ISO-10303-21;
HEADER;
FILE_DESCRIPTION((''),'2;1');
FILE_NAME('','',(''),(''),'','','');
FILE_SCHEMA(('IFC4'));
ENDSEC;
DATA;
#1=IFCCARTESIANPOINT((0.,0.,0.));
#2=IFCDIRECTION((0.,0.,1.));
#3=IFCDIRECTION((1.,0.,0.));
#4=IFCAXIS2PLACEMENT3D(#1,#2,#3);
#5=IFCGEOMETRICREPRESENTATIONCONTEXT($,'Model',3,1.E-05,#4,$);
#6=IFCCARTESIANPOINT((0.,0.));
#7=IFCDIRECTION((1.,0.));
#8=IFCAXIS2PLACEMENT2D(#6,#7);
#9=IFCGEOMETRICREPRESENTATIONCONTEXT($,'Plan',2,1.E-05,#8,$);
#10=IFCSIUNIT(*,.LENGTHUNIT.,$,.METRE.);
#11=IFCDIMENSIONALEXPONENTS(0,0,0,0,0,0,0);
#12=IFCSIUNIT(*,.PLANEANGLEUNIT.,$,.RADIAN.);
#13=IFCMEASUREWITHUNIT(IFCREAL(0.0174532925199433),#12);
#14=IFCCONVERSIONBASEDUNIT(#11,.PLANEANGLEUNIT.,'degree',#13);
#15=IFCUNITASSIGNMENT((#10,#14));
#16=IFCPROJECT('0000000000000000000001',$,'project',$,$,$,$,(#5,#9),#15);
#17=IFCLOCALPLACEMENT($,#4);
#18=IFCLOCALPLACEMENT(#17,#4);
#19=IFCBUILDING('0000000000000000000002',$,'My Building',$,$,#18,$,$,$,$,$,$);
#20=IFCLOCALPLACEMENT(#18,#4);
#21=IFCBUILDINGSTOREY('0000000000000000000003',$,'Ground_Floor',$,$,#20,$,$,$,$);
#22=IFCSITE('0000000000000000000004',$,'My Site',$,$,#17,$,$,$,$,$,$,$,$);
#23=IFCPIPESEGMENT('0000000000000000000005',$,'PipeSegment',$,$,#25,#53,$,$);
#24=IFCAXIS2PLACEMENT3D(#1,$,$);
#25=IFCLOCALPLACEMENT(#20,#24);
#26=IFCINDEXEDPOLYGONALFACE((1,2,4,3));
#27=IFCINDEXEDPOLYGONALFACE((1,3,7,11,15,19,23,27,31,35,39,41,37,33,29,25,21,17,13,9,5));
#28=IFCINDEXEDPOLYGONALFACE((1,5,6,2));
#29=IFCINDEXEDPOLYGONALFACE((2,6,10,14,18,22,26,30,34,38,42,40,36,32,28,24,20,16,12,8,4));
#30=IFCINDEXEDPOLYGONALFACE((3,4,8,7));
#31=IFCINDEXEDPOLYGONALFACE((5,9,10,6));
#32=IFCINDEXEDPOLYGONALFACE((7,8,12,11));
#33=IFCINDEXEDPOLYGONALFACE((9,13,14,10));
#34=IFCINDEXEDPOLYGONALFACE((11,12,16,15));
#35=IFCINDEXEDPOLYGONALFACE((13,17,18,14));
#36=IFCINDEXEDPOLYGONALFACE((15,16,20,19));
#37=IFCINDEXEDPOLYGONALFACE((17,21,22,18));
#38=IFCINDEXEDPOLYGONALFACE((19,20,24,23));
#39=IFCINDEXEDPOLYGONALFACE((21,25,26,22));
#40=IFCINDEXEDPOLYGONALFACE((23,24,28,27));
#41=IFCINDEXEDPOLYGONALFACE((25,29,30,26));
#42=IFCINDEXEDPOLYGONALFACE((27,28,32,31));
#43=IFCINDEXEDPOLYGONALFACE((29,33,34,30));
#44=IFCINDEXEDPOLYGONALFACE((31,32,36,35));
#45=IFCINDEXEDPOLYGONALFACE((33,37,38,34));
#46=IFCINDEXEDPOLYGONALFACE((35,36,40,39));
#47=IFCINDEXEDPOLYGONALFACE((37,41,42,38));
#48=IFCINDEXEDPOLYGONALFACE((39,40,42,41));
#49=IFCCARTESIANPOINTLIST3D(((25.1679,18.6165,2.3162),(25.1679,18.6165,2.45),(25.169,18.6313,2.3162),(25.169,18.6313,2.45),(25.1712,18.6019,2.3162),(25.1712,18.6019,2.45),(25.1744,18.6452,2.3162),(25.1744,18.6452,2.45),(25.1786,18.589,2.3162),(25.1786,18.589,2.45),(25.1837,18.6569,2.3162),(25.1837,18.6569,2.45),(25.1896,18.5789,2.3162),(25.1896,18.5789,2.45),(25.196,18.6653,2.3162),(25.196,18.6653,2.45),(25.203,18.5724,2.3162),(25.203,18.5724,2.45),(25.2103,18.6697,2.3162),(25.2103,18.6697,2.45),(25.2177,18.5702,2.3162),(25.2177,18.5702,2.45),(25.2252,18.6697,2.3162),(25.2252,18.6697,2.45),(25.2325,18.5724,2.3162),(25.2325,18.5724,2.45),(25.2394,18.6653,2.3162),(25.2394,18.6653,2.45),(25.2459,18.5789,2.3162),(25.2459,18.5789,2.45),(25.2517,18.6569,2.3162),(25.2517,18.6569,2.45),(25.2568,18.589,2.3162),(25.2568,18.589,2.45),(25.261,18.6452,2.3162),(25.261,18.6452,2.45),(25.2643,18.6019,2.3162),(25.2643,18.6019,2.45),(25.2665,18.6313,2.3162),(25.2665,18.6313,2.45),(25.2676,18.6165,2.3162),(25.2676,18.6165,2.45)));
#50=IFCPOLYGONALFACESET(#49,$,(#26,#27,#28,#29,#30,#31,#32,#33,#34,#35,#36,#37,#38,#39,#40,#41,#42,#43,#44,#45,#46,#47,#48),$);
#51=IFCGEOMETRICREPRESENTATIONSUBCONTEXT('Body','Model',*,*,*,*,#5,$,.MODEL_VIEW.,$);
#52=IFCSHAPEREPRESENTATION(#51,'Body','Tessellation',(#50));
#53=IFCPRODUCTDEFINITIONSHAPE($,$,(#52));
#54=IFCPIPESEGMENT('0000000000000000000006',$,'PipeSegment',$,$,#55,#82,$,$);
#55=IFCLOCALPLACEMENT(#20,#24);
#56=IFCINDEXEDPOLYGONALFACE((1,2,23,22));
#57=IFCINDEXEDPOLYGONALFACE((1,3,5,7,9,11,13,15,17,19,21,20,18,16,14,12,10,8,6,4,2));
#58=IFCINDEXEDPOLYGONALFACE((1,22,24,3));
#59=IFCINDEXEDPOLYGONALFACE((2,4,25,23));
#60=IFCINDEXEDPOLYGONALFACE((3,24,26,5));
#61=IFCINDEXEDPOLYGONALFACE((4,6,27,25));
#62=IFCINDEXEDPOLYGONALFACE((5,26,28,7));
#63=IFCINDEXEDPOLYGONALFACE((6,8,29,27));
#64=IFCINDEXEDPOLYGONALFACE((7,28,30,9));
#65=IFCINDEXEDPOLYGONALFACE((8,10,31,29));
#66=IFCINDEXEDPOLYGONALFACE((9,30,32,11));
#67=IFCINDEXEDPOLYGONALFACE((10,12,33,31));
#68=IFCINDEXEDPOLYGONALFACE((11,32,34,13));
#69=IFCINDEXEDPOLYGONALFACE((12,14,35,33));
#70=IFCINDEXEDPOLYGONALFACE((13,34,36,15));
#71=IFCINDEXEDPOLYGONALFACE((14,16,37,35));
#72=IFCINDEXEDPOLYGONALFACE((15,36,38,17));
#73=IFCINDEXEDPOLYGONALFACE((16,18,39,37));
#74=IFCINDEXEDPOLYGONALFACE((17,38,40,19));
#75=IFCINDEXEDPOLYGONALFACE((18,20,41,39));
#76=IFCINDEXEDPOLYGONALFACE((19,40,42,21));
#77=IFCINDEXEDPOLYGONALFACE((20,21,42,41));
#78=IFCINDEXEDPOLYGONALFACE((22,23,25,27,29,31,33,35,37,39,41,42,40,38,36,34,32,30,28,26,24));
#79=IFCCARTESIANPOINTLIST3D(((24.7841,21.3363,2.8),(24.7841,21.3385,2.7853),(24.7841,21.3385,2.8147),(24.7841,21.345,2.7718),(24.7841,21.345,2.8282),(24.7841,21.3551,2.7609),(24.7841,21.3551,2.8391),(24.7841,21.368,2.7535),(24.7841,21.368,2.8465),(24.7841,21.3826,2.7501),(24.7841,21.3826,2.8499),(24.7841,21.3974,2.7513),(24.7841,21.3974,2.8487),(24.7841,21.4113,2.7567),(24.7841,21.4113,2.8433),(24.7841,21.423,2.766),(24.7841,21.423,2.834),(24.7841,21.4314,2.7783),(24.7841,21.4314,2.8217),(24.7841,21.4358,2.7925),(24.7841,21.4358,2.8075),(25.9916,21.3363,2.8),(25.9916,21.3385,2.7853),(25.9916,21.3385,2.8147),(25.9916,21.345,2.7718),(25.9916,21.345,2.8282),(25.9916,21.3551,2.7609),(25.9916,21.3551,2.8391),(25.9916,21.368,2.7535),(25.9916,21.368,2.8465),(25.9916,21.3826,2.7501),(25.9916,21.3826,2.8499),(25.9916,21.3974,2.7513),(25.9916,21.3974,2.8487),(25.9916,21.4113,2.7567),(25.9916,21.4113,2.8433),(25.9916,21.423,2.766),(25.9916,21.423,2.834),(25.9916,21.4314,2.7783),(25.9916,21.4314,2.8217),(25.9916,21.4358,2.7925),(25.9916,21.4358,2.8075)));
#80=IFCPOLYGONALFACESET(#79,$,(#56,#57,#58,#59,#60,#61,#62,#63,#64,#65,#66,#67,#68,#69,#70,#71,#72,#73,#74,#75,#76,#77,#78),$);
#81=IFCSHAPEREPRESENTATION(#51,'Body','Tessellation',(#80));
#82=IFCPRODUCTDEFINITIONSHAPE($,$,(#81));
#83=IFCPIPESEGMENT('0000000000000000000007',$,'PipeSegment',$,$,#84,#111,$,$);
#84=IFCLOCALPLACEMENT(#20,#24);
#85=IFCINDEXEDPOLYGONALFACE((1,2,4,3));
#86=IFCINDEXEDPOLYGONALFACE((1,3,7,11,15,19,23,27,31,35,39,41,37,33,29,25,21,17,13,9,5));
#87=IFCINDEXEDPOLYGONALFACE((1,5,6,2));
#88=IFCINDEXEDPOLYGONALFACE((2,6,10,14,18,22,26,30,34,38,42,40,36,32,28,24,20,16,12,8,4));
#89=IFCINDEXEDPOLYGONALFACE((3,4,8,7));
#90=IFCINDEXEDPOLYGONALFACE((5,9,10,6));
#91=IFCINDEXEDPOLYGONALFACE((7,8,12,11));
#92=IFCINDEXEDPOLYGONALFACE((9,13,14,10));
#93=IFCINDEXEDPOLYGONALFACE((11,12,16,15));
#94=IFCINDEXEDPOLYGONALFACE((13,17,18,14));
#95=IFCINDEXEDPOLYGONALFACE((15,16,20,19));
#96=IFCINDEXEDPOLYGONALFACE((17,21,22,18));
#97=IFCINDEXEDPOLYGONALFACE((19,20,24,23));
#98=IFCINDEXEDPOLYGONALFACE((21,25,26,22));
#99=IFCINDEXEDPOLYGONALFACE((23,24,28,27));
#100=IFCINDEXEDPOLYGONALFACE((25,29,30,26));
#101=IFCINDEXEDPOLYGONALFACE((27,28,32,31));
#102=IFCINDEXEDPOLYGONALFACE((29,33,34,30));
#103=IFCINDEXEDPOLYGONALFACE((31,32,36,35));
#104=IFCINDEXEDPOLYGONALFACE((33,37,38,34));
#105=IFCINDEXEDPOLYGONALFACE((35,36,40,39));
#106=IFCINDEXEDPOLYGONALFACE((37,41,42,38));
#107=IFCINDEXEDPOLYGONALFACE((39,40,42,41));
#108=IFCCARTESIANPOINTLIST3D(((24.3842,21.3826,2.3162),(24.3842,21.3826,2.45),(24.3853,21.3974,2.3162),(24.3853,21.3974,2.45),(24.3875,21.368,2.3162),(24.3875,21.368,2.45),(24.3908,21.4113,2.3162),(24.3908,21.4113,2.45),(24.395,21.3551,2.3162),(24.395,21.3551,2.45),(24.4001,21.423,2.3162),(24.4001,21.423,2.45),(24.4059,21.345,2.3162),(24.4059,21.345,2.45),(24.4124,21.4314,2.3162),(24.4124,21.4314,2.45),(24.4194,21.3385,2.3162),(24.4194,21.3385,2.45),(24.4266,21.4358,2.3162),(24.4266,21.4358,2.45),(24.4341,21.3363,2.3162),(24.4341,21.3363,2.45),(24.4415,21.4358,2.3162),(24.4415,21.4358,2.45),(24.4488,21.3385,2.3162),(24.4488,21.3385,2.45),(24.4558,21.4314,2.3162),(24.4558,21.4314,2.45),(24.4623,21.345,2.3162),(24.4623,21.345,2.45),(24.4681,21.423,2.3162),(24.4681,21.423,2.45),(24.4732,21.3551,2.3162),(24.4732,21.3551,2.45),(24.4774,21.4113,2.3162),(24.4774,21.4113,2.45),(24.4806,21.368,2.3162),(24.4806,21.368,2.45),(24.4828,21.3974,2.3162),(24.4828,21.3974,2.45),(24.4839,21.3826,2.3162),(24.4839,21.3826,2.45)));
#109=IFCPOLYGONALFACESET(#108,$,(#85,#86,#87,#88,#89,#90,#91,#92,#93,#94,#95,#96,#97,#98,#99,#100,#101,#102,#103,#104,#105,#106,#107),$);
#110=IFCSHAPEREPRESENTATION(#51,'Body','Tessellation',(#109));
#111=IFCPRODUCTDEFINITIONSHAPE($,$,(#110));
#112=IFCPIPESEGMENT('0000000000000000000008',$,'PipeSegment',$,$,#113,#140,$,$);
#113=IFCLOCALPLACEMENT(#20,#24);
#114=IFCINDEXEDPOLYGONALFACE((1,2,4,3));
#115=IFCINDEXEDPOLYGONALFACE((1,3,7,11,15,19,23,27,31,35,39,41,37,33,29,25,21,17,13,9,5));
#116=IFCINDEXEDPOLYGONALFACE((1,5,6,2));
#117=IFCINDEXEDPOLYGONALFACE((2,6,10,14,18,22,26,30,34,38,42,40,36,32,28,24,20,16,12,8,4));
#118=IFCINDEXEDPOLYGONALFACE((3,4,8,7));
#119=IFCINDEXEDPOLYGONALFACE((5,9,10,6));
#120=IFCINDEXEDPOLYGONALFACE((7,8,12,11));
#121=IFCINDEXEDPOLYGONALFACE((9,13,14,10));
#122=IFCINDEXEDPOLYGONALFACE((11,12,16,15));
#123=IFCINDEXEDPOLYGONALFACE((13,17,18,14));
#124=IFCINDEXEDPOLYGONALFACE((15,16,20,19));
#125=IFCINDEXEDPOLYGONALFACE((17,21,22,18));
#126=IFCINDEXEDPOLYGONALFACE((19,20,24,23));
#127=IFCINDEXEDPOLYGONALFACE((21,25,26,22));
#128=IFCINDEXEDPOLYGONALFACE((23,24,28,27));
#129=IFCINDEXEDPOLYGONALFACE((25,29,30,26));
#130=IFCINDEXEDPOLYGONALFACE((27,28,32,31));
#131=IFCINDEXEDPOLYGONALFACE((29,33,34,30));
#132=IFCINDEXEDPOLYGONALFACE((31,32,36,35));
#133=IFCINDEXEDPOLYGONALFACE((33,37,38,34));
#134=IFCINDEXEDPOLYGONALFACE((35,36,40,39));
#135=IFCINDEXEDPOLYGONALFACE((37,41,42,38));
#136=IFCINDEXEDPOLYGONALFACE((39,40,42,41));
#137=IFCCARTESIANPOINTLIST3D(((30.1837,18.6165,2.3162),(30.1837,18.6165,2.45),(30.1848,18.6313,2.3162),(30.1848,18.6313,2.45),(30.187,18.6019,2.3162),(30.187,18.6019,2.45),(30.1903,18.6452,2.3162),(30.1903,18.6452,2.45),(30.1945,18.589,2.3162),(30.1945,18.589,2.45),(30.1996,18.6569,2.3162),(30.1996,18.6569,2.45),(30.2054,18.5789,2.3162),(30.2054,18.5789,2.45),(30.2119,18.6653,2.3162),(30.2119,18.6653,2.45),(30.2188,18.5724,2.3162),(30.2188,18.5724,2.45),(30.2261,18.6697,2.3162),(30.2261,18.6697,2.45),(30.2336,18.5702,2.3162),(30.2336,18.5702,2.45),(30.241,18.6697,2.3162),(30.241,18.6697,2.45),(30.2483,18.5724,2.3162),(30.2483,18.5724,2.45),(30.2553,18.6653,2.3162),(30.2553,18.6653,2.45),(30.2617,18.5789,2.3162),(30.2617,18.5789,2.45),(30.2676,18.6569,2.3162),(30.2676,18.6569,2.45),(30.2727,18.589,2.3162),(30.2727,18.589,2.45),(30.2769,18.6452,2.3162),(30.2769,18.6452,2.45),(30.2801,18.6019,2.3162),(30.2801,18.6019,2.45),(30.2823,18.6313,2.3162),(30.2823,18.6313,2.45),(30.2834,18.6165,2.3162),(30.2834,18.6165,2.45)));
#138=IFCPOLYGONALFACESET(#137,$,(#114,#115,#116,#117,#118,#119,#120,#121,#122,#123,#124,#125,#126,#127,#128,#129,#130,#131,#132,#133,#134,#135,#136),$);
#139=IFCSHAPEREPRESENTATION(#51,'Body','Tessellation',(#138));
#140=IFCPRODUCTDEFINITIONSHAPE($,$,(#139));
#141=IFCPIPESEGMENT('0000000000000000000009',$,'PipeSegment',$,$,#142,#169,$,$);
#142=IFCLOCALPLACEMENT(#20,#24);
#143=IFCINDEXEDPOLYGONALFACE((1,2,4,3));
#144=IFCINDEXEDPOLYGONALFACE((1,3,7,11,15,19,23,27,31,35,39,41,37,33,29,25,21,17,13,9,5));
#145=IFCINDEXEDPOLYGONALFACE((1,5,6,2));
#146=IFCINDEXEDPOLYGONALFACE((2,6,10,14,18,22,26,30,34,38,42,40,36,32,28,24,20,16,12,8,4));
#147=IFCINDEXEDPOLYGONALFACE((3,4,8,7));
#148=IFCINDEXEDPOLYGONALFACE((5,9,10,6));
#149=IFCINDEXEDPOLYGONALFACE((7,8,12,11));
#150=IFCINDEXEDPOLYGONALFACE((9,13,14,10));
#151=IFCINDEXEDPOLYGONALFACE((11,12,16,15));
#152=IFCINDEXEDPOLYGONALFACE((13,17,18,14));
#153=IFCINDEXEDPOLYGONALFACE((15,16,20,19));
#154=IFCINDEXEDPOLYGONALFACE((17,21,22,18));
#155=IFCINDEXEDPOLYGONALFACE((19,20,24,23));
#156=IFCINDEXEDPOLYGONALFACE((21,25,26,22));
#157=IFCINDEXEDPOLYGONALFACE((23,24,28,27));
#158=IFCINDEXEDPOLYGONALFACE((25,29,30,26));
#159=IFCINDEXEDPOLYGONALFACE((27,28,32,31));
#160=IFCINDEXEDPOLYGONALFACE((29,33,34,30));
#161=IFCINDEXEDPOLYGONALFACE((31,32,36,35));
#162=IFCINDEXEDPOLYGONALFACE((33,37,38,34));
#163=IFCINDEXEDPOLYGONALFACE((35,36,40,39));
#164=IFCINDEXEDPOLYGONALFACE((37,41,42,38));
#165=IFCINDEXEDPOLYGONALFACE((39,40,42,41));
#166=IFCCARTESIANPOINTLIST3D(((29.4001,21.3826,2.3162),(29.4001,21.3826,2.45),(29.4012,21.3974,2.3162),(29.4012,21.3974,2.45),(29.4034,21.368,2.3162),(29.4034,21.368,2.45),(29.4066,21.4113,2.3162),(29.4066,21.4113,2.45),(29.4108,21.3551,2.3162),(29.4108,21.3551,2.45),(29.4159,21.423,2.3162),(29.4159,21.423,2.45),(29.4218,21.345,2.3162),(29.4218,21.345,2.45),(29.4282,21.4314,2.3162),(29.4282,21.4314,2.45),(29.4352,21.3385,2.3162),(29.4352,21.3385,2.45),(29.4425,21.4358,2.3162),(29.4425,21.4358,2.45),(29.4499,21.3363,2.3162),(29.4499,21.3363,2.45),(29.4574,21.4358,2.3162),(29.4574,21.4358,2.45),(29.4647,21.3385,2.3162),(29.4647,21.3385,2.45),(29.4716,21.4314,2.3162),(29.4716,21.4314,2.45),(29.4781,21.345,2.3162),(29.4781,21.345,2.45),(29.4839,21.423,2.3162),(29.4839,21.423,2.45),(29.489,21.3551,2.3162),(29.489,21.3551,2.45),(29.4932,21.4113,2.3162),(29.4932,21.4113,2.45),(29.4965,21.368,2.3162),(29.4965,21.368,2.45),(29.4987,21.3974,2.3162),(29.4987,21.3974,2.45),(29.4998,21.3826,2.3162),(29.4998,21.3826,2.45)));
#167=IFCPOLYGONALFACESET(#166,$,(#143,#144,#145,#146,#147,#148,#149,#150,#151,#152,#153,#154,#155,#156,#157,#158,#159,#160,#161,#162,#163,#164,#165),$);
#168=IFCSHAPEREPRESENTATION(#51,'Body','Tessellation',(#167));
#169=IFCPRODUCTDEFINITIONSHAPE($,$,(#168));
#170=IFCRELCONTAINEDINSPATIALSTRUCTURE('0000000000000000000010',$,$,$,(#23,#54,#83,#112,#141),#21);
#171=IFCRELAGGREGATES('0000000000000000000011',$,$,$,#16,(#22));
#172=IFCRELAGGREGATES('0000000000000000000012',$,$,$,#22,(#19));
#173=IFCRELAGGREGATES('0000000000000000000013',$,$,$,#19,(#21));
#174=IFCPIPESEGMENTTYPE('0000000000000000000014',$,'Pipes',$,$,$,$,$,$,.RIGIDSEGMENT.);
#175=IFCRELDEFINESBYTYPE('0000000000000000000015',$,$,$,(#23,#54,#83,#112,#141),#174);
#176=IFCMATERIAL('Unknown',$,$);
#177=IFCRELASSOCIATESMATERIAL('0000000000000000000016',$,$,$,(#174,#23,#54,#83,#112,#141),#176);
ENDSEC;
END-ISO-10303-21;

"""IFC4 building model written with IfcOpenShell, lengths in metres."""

from ifc_helpers import new_model, entity, si_unit, converted_unit, frame, origin_with_axes, origin_2d_with_axis, place, context, subcontext, project, spatial, circle, extrude, material, material_profile, profile_set, profile_usage, type_object, element, save


model = new_model("IFC4")

# Units and contexts
model_context = context("Model", 3, precision=1e-05, world=origin_with_axes())
plan_context = context("Plan", 2, precision=1e-05, world=origin_2d_with_axis())
body_context = subcontext(model_context, "Body", "Model", "MODEL_VIEW")
ifc_project = project(units=[si_unit("LENGTHUNIT", "METRE"), converted_unit("PLANEANGLEUNIT", "degree", entity("IfcReal", 0.0174532925199433), si_unit("PLANEANGLEUNIT", "RADIAN"), dimensions=[0, 0, 0, 0, 0, 0, 0])], contexts=[model_context, plan_context])

# Site, building, storey
site_placement = place(None, origin_with_axes())
site = spatial("IfcSite", under=ifc_project, at=site_placement, Name="My Site")
building_placement = place(site_placement, origin_with_axes())
building = spatial("IfcBuilding", under=site, at=building_placement, Name="My Building")
storey_placement = place(building_placement, origin_with_axes())
storey = spatial("IfcBuildingStorey", under=building, at=storey_placement, Name="Ground_Floor")

# Shared definitions
ifc_material = material(Name="Unknown")

# Pipe segments
ifc_material_profile_1 = material_profile(ifc_material, circle(Radius=0.05))
ifc_profile_set_1 = profile_set([ifc_material_profile_1])
pipe_segment_type = type_object("IfcPipeSegmentType", Name="Pipes", PredefinedType="RIGIDSEGMENT", material=ifc_profile_set_1)
ifc_profile_usage_1 = profile_usage(ifc_profile_set_1, cardinal=5)
pipe_segment_1_placement = place(storey_placement, frame((25.2177, 18.6202, 2.45), z_axis=(0.0, 0.0, -1.0), x_axis=(0.0, -1.0, 0.0)))
element("IfcPipeSegment", 1, at=pipe_segment_1_placement, inside=storey, type_object=pipe_segment_type, material=ifc_profile_usage_1, Name="PipeSegment", context=body_context, shape_type="SweptSolid", body=[
    extrude(circle(Radius=0.05), origin_with_axes(), (0.0, 0.0, 1.0), 0.1338),
])
ifc_profile_usage_2 = profile_usage(ifc_profile_set_1, cardinal=5)
pipe_segment_2_placement = place(storey_placement, frame((25.9916, 21.3863, 2.8), z_axis=(-1.0, 0.0, 0.0), x_axis=(0.0, -1.0, 0.0)))
element("IfcPipeSegment", 2, at=pipe_segment_2_placement, inside=storey, type_object=pipe_segment_type, material=ifc_profile_usage_2, Name="PipeSegment", context=body_context, shape_type="SweptSolid", body=[
    extrude(circle(Radius=0.05), origin_with_axes(), (0.0, 0.0, 1.0), 1.2075),
])
ifc_profile_usage_3 = profile_usage(ifc_profile_set_1, cardinal=5)
pipe_segment_3_placement = place(storey_placement, frame((24.4341, 21.3863, 2.45), z_axis=(0.0, 0.0, -1.0), x_axis=(0.0, -1.0, 0.0)))
element("IfcPipeSegment", 3, at=pipe_segment_3_placement, inside=storey, type_object=pipe_segment_type, material=ifc_profile_usage_3, Name="PipeSegment", context=body_context, shape_type="SweptSolid", body=[
    extrude(circle(Radius=0.05), origin_with_axes(), (0.0, 0.0, 1.0), 0.1338),
])
ifc_profile_usage_4 = profile_usage(ifc_profile_set_1, cardinal=5)
pipe_segment_4_placement = place(storey_placement, frame((30.2336, 18.6202, 2.45), z_axis=(0.0, 0.0, -1.0), x_axis=(0.0, -1.0, 0.0)))
element("IfcPipeSegment", 4, at=pipe_segment_4_placement, inside=storey, type_object=pipe_segment_type, material=ifc_profile_usage_4, Name="PipeSegment", context=body_context, shape_type="SweptSolid", body=[
    extrude(circle(Radius=0.05), origin_with_axes(), (0.0, 0.0, 1.0), 0.1338),
])
ifc_profile_usage_5 = profile_usage(ifc_profile_set_1, cardinal=5)
pipe_segment_5_placement = place(storey_placement, frame((29.4499, 21.3863, 2.45), z_axis=(0.0, 0.0, -1.0), x_axis=(0.0, -1.0, 0.0)))
element("IfcPipeSegment", 5, at=pipe_segment_5_placement, inside=storey, type_object=pipe_segment_type, material=ifc_profile_usage_5, Name="PipeSegment", context=body_context, shape_type="SweptSolid", body=[
    extrude(circle(Radius=0.05), origin_with_axes(), (0.0, 0.0, 1.0), 0.1338),
])

save(model, "model.ifc")
